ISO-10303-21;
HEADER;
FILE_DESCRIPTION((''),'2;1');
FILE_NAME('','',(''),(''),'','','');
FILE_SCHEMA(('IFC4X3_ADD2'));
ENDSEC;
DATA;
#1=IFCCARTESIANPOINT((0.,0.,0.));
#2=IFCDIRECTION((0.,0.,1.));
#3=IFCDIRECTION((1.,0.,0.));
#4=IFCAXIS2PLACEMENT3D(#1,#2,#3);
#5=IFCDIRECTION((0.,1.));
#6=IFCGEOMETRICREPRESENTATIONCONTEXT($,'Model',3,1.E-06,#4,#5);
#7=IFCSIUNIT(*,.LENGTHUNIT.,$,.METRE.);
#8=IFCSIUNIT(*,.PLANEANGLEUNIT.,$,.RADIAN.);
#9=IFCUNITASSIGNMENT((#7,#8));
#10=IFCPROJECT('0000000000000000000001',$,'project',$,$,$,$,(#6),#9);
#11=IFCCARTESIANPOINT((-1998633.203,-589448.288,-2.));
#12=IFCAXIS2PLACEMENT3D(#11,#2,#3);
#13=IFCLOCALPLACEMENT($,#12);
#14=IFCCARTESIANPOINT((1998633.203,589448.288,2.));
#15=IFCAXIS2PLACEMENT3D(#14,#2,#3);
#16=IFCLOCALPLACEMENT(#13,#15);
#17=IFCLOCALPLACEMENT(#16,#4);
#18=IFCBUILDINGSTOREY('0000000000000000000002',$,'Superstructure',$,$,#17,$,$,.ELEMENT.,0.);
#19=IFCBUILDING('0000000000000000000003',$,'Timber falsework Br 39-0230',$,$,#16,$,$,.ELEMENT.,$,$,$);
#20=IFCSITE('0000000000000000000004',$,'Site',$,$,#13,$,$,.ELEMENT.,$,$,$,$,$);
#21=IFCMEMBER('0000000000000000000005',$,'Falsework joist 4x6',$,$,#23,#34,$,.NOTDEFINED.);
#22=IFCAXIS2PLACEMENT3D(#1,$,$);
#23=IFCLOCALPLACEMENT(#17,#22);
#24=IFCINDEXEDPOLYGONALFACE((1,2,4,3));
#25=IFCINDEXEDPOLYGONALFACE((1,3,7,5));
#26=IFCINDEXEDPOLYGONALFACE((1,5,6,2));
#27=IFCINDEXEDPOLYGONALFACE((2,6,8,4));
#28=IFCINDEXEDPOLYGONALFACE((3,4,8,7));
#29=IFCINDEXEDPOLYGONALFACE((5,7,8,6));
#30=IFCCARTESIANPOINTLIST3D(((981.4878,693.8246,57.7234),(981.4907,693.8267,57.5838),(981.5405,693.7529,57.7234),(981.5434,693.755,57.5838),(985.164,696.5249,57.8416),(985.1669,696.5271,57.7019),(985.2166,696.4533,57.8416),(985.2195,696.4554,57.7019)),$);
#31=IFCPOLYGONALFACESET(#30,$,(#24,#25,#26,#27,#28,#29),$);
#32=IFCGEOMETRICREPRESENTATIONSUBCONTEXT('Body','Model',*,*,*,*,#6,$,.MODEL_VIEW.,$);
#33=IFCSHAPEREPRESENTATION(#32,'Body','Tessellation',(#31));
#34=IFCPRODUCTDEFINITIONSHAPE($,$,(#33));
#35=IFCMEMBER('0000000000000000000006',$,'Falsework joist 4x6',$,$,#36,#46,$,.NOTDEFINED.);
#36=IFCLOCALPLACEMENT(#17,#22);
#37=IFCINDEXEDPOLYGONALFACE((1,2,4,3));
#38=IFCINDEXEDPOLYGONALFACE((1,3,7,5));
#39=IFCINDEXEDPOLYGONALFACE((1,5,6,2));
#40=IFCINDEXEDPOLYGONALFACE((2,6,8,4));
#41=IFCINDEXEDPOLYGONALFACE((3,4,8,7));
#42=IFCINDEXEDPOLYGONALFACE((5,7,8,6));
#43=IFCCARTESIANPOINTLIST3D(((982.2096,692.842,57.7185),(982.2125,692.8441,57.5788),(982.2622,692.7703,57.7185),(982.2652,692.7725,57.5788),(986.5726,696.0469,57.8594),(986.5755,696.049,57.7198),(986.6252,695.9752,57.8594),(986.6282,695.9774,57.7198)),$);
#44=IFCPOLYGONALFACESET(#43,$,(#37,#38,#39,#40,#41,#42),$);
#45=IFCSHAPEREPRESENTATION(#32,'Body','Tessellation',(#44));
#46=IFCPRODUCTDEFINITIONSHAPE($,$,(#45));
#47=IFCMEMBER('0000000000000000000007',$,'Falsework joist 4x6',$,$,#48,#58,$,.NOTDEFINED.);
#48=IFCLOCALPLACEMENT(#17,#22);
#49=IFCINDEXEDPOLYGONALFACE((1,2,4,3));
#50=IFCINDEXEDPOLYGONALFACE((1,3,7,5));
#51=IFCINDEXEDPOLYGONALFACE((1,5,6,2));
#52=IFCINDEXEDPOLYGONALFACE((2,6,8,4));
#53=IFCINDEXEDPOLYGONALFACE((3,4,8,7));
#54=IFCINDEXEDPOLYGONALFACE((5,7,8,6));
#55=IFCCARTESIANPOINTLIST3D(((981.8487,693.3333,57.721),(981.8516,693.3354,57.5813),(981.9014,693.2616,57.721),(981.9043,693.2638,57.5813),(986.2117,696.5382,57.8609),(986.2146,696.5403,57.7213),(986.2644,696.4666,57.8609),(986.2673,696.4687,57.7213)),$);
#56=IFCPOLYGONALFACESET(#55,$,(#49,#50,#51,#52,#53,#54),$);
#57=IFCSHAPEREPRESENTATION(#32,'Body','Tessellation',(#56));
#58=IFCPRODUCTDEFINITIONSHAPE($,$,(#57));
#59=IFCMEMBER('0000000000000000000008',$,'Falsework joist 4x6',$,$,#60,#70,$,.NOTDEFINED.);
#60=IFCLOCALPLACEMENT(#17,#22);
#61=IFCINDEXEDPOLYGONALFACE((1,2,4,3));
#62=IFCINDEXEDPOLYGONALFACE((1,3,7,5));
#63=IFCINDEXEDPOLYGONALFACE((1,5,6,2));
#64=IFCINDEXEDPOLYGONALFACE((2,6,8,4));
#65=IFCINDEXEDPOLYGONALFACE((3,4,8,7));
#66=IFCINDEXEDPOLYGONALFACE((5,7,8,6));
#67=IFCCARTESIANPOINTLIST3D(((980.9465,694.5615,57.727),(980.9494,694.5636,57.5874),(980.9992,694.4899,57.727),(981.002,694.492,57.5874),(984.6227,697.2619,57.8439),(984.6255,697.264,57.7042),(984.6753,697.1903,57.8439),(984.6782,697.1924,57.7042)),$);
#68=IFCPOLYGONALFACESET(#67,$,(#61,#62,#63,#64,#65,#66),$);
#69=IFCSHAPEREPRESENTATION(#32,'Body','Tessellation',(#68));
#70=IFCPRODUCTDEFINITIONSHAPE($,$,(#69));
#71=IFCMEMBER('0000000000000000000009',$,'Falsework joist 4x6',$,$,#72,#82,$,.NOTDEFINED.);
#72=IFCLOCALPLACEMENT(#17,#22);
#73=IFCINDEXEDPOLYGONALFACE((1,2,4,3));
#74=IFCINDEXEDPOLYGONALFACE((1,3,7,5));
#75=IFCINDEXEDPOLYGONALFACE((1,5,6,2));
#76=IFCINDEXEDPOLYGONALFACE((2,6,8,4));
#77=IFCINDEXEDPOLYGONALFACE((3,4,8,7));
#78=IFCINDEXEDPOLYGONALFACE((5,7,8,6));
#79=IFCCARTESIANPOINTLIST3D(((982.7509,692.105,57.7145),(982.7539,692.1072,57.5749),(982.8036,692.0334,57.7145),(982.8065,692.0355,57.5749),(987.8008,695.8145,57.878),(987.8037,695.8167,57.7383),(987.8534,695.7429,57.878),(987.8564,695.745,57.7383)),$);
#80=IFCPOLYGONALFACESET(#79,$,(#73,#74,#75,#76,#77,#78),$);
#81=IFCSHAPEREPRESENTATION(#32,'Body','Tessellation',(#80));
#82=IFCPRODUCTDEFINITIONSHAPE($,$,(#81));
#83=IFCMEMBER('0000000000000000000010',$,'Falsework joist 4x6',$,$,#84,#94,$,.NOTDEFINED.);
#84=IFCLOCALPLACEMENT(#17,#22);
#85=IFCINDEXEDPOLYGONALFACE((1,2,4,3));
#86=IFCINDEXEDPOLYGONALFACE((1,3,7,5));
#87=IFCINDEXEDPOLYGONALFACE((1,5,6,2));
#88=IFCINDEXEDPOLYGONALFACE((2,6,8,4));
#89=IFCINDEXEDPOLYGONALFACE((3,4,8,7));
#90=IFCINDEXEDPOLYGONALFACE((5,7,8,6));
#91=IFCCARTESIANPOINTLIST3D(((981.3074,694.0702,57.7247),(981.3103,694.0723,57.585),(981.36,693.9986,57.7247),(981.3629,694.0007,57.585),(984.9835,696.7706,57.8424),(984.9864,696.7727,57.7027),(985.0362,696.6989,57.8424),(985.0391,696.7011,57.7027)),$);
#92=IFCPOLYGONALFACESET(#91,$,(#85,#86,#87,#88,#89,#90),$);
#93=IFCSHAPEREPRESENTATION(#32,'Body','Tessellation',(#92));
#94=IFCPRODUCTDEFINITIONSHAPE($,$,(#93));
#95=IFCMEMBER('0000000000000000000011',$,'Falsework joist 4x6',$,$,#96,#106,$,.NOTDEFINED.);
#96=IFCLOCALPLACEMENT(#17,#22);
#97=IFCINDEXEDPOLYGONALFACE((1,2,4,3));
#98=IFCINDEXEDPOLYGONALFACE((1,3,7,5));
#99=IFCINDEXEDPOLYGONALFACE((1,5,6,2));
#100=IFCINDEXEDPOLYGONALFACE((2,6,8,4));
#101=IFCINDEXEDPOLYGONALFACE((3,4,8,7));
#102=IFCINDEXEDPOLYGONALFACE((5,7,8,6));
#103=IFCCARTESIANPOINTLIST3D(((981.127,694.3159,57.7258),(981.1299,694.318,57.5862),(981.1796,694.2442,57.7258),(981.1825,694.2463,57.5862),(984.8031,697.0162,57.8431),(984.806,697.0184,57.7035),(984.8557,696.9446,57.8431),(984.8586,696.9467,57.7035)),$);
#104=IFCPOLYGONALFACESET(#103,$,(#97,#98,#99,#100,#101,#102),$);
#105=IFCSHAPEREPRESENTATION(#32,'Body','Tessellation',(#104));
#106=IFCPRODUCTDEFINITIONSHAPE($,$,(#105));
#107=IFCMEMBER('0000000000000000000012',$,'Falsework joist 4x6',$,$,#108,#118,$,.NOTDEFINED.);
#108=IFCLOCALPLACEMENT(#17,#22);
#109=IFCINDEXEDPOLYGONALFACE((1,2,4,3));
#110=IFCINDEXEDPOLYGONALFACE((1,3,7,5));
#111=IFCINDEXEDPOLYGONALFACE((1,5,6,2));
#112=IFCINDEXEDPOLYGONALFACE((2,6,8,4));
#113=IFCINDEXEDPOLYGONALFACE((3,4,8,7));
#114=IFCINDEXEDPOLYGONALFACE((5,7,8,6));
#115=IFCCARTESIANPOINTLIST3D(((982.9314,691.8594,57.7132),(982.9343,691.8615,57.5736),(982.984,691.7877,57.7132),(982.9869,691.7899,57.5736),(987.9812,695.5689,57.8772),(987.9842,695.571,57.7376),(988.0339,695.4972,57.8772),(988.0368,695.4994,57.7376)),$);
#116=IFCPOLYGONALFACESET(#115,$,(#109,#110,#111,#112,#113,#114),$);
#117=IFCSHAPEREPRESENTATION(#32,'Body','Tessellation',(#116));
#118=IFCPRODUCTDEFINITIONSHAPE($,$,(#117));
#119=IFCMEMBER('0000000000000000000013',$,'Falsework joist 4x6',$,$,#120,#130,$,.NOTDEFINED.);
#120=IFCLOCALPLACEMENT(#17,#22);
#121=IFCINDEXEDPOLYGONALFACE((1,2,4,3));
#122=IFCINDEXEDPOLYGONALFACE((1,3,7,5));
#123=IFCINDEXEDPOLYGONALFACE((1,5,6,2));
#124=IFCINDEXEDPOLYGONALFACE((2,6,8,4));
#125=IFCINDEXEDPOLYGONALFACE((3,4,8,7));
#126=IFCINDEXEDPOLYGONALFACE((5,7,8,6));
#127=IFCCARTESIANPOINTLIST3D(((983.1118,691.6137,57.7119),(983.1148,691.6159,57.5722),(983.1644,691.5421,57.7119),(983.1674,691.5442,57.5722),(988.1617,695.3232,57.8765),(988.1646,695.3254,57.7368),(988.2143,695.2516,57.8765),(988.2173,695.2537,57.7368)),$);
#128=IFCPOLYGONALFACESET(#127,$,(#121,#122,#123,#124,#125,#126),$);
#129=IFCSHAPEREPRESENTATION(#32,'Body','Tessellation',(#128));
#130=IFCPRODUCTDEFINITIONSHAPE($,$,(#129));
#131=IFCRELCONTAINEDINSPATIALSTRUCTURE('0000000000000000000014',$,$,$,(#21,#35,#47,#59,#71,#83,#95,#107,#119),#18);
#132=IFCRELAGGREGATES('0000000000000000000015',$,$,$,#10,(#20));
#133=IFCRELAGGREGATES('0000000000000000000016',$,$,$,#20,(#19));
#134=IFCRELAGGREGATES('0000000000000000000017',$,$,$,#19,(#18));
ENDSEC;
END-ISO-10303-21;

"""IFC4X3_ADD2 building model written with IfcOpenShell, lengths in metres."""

from ifc_helpers import new_model, si_unit, direction, frame, frame_2d, origin, origin_with_axes, place, context, subcontext, project, spatial, rectangle, extrude, element, save


model = new_model("IFC4X3_ADD2")

# Units and contexts
model_context = context("Model", 3, precision=1e-06, world=origin_with_axes(), true_north=direction((0.0, 1.0)))
body_context = subcontext(model_context, "Body", "Model", "MODEL_VIEW")
ifc_project = project(units=[si_unit("LENGTHUNIT", "METRE"), si_unit("PLANEANGLEUNIT", "RADIAN")], contexts=[model_context])

# Site, building, storey
site_placement = place(None, frame((-1998633.203, -589448.288, -2.0), z_axis=(0.0, 0.0, 1.0), x_axis=(1.0, 0.0, 0.0)))
site = spatial("IfcSite", under=ifc_project, at=site_placement, Name="Site", CompositionType="ELEMENT")
building_placement = place(site_placement, frame((1998633.203, 589448.288, 2.0), z_axis=(0.0, 0.0, 1.0), x_axis=(1.0, 0.0, 0.0)))
building = spatial("IfcBuilding", under=site, at=building_placement, Name="Timber falsework Br 39-0230", CompositionType="ELEMENT")
storey_placement = place(building_placement, origin_with_axes())
storey = spatial("IfcBuildingStorey", under=building, at=storey_placement, Name="Superstructure", CompositionType="ELEMENT", Elevation=0.0)

# Members
member_1_placement = place(storey_placement, frame((981.5171, 693.7909, 57.5838), z_axis=(0.805658, 0.591815, 0.02589), x_axis=(-0.592013, 0.805928, 0.0)))
element("IfcMember", 1, at=member_1_placement, inside=storey, Name="Falsework joist 4x6", PredefinedType="NOTDEFINED", context=body_context, shape_type="SweptSolid", body=[
    extrude(rectangle(XDim=0.0889, YDim=0.1397, at=frame_2d((0.0, 0.0698))), origin(), (0.0, 0.0, 1.0), 4.5629),
])
member_2_placement = place(storey_placement, frame((982.2388, 692.8083, 57.5788), z_axis=(0.805655, 0.591813, 0.02603), x_axis=(-0.592013, 0.805928, 0.0)))
element("IfcMember", 2, at=member_2_placement, inside=storey, Name="Falsework joist 4x6", PredefinedType="NOTDEFINED", context=body_context, shape_type="SweptSolid", body=[
    extrude(rectangle(XDim=0.0889, YDim=0.1397, at=frame_2d((0.0, 0.0698))), origin(), (0.0, 0.0, 1.0), 5.4155),
])
member_3_placement = place(storey_placement, frame((981.878, 693.2996, 57.5813), z_axis=(0.805659, 0.591815, 0.025841), x_axis=(-0.592013, 0.805928, 0.0)))
element("IfcMember", 3, at=member_3_placement, inside=storey, Name="Falsework joist 4x6", PredefinedType="NOTDEFINED", context=body_context, shape_type="SweptSolid", body=[
    extrude(rectangle(XDim=0.0889, YDim=0.1397, at=frame_2d((0.0, 0.0698))), origin(), (0.0, 0.0, 1.0), 5.4154),
])
member_4_placement = place(storey_placement, frame((980.9757, 694.5278, 57.5874), z_axis=(0.805664, 0.591819, 0.025606), x_axis=(-0.592013, 0.805928, 0.0)))
element("IfcMember", 4, at=member_4_placement, inside=storey, Name="Falsework joist 4x6", PredefinedType="NOTDEFINED", context=body_context, shape_type="SweptSolid", body=[
    extrude(rectangle(XDim=0.0889, YDim=0.1397, at=frame_2d((0.0, 0.0698))), origin(), (0.0, 0.0, 1.0), 4.5629),
])
member_5_placement = place(storey_placement, frame((982.7802, 692.0713, 57.5749), z_axis=(0.805654, 0.591812, 0.026076), x_axis=(-0.592013, 0.805928, 0.0)))
element("IfcMember", 5, at=member_5_placement, inside=storey, Name="Falsework joist 4x6", PredefinedType="NOTDEFINED", context=body_context, shape_type="SweptSolid", body=[
    extrude(rectangle(XDim=0.0889, YDim=0.1397, at=frame_2d((0.0, 0.0698))), origin(), (0.0, 0.0, 1.0), 6.268),
])
member_6_placement = place(storey_placement, frame((981.3366, 694.0365, 57.585), z_axis=(0.80566, 0.591816, 0.025795), x_axis=(-0.592013, 0.805928, 0.0)))
element("IfcMember", 6, at=member_6_placement, inside=storey, Name="Falsework joist 4x6", PredefinedType="NOTDEFINED", context=body_context, shape_type="SweptSolid", body=[
    extrude(rectangle(XDim=0.0889, YDim=0.1397, at=frame_2d((0.0, 0.0698))), origin(), (0.0, 0.0, 1.0), 4.5629),
])
member_7_placement = place(storey_placement, frame((981.1562, 694.2822, 57.5862), z_axis=(0.805662, 0.591818, 0.025701), x_axis=(-0.592013, 0.805928, 0.0)))
element("IfcMember", 7, at=member_7_placement, inside=storey, Name="Falsework joist 4x6", PredefinedType="NOTDEFINED", context=body_context, shape_type="SweptSolid", body=[
    extrude(rectangle(XDim=0.0889, YDim=0.1397, at=frame_2d((0.0, 0.0698))), origin(), (0.0, 0.0, 1.0), 4.5629),
])
member_8_placement = place(storey_placement, frame((982.9606, 691.8257, 57.5736), z_axis=(0.805652, 0.59181, 0.026171), x_axis=(-0.592013, 0.805928, 0.0)))
element("IfcMember", 8, at=member_8_placement, inside=storey, Name="Falsework joist 4x6", PredefinedType="NOTDEFINED", context=body_context, shape_type="SweptSolid", body=[
    extrude(rectangle(XDim=0.0889, YDim=0.1397, at=frame_2d((0.0, 0.0698))), origin(), (0.0, 0.0, 1.0), 6.2681),
])
member_9_placement = place(storey_placement, frame((983.1411, 691.58, 57.5722), z_axis=(0.80565, 0.591809, 0.026265), x_axis=(-0.592013, 0.805928, 0.0)))
element("IfcMember", 9, at=member_9_placement, inside=storey, Name="Falsework joist 4x6", PredefinedType="NOTDEFINED", context=body_context, shape_type="SweptSolid", body=[
    extrude(rectangle(XDim=0.0889, YDim=0.1397, at=frame_2d((0.0, 0.0698))), origin(), (0.0, 0.0, 1.0), 6.2681),
])

save(model, "model.ifc")
